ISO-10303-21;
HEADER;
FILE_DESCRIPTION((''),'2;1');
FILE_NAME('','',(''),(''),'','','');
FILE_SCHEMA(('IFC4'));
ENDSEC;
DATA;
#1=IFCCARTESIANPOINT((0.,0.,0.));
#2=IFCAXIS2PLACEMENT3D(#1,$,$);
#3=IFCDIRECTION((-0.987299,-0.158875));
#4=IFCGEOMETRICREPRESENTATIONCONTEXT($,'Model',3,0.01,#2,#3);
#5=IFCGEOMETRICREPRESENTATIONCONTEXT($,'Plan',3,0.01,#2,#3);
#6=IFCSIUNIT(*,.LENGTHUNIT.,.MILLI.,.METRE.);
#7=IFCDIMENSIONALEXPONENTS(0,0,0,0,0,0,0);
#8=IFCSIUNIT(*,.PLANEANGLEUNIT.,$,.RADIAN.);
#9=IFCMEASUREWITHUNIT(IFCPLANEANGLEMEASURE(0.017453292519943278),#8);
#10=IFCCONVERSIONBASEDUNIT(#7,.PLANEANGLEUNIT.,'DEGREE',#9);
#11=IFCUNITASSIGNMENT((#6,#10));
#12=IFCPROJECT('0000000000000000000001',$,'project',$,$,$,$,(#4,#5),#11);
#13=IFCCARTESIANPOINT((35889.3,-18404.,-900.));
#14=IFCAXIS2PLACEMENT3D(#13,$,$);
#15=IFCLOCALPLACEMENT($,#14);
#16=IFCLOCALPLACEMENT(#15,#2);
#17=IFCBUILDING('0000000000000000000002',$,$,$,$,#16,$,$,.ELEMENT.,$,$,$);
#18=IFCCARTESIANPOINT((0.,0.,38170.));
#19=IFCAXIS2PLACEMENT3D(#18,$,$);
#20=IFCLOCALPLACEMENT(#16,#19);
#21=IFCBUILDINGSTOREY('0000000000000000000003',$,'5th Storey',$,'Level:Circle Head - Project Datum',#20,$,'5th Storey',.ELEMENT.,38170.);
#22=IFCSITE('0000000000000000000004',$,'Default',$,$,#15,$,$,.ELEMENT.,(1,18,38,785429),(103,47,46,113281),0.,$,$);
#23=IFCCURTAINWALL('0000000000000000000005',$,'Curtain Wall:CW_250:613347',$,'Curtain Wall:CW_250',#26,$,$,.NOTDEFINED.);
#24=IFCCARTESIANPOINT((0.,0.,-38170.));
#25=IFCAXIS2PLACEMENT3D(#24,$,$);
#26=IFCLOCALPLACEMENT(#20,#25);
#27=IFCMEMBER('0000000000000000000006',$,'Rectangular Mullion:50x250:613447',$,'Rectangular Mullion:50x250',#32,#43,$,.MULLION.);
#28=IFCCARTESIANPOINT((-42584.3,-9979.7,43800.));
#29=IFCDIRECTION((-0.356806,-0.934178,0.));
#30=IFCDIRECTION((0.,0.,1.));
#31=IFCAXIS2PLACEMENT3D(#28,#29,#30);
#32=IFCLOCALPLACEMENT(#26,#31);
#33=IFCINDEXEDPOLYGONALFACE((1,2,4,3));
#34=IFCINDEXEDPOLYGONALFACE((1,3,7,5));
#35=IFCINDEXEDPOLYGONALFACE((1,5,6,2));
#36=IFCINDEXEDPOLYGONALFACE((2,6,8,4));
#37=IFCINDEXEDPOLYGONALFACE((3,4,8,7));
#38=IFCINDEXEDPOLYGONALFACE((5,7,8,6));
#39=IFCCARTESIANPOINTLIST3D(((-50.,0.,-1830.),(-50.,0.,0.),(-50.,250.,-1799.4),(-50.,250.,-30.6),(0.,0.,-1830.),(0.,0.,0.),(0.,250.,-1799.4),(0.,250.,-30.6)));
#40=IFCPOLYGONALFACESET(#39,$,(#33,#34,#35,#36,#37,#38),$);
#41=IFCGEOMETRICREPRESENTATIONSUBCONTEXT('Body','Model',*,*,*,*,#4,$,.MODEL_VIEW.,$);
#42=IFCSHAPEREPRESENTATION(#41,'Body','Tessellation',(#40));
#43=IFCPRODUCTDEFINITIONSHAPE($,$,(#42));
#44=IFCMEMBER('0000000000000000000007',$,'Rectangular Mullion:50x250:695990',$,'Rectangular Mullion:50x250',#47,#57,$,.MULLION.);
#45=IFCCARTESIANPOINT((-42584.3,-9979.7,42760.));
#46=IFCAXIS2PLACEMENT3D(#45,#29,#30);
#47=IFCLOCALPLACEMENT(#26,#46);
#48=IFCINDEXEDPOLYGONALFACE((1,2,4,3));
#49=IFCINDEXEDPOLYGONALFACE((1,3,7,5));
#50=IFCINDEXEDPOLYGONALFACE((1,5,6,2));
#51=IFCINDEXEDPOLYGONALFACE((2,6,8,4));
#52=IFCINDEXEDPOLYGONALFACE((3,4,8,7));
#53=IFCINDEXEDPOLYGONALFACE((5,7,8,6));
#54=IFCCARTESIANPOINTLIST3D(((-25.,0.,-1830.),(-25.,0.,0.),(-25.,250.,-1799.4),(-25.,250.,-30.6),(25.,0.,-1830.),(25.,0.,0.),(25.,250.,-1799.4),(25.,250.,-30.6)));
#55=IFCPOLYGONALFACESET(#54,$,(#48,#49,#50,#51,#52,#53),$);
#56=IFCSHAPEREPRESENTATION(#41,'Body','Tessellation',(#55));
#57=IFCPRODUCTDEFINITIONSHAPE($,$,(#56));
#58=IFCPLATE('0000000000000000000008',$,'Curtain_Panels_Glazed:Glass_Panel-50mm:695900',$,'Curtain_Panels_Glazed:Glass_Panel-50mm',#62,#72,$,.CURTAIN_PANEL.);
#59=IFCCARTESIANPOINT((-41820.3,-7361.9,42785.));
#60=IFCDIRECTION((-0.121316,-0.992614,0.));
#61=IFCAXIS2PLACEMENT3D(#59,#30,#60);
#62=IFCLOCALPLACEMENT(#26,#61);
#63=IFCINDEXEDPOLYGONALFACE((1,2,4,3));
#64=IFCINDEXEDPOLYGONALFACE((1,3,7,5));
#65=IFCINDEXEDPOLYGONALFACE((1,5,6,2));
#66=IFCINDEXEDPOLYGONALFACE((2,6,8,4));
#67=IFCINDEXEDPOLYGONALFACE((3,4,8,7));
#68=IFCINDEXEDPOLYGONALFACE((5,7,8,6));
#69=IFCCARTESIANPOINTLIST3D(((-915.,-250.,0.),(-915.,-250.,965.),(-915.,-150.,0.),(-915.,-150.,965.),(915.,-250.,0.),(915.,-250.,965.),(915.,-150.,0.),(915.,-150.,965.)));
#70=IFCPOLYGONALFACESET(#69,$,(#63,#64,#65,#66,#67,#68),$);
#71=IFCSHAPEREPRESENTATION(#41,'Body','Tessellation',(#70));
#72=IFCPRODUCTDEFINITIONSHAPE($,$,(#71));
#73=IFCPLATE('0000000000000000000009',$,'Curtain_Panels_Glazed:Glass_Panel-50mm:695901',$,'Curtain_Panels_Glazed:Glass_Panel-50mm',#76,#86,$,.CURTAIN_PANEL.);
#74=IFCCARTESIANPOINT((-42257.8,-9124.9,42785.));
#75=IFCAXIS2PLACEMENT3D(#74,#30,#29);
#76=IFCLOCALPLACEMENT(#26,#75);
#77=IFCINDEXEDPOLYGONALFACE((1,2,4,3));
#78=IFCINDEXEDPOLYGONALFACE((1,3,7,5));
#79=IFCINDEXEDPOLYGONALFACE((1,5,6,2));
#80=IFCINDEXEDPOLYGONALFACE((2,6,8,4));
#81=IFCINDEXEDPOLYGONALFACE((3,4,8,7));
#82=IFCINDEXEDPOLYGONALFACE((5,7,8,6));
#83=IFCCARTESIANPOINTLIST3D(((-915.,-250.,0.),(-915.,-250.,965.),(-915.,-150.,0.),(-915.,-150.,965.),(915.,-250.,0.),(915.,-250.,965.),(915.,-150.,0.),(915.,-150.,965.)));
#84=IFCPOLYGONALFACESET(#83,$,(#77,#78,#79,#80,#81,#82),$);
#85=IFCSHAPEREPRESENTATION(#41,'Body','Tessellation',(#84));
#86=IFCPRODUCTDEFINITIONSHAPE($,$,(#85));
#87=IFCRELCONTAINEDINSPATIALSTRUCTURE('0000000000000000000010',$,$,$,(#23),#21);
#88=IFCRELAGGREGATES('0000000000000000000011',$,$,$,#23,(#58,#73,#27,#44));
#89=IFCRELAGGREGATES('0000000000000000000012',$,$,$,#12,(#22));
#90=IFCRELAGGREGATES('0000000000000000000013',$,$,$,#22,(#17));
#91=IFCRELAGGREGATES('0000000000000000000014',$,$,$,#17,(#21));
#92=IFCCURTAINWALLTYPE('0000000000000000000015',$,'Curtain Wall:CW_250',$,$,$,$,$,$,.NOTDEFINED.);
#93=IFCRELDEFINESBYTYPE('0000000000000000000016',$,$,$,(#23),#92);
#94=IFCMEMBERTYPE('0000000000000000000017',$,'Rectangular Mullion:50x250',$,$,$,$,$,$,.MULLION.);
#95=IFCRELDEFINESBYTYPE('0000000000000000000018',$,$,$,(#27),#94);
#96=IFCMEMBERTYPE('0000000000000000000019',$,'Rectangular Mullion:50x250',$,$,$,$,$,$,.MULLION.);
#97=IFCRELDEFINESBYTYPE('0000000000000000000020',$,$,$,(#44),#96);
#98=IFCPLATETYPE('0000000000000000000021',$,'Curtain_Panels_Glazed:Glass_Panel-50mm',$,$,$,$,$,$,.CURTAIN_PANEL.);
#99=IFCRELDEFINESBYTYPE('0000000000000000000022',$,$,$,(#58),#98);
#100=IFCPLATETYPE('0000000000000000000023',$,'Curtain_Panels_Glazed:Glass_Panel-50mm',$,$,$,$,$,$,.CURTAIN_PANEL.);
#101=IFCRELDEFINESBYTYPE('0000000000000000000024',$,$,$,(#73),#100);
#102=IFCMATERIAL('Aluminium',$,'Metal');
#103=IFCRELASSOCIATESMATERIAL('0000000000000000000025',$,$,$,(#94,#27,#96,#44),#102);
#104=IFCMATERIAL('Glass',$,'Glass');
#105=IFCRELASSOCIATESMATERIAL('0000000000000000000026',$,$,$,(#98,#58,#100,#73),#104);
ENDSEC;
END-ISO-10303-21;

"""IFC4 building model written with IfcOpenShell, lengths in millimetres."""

from ifc_helpers import new_model, entity, si_unit, converted_unit, direction, frame, origin, place, context, subcontext, project, spatial, indexed_curve, outline, extrude, source, transform, mapped, material, type_object, type_shapes, element, aggregate, save


model = new_model("IFC4")

# Units and contexts
model_context = context("Model", 3, precision=0.01, world=origin(), true_north=direction((-0.987299, -0.158875)))
plan_context = context("Plan", 3, precision=0.01, world=origin(), true_north=direction((-0.987299, -0.158875)))
body_context = subcontext(model_context, "Body", "Model", "MODEL_VIEW")
ifc_project = project(units=[si_unit("LENGTHUNIT", "METRE", prefix="MILLI"), converted_unit("PLANEANGLEUNIT", "DEGREE", entity("IfcPlaneAngleMeasure", 0.017453292519943278), si_unit("PLANEANGLEUNIT", "RADIAN"), dimensions=[0, 0, 0, 0, 0, 0, 0])], contexts=[model_context, plan_context])

# Site, building, storey
site_placement = place(None, frame((35889.3, -18404.0, -900.0)))
site = spatial("IfcSite", under=ifc_project, at=site_placement, Name="Default", CompositionType="ELEMENT", RefLatitude=(1, 18, 38, 785429), RefLongitude=(103, 47, 46, 113281), RefElevation=0.0)
building_placement = place(site_placement, origin())
building = spatial("IfcBuilding", under=site, at=building_placement, CompositionType="ELEMENT")
storey_placement = place(building_placement, frame((0.0, 0.0, 38170.0)))
storey = spatial("IfcBuildingStorey", under=building, at=storey_placement, Name="5th Storey", ObjectType="Level:Circle Head - Project Datum", LongName="5th Storey", CompositionType="ELEMENT", Elevation=38170.0)

# Curtain wall, member
curtain_wall_type = type_object("IfcCurtainWallType", Name="Curtain Wall:CW_250", PredefinedType="NOTDEFINED")
ifc_material_1 = material(Name="Aluminium", Category="Metal")
curtain_wall_1_placement = place(storey_placement, frame((0.0, 0.0, -38170.0)))
curtain_wall_1 = element("IfcCurtainWall", 1, at=curtain_wall_1_placement, inside=storey, type_object=curtain_wall_type, Name="Curtain Wall:CW_250:613347", ObjectType="Curtain Wall:CW_250", PredefinedType="NOTDEFINED")
member_type_1 = type_object("IfcMemberType", Name="Rectangular Mullion:50x250", PredefinedType="MULLION", material=ifc_material_1)
shared_shape_1 = source(origin(), body_context, "Body", "SweptSolid", [
    extrude(outline(indexed_curve([(-915.0, -125.0), (915.0, -125.0), (884.4, 125.0), (-884.4, 125.0), (-915.0, -125.0)], self_intersect=False)), frame((-50.0, 125.0, -915.0), z_axis=(1.0, 0.0, 0.0), x_axis=(0.0, 0.0, -1.0)), (0.0, 0.0, 1.0), 50.0),
])
type_shapes(member_type_1, [shared_shape_1])
member_1_placement = place(curtain_wall_1_placement, frame((-42584.3, -9979.7, 43800.0), z_axis=(-0.356806, -0.934178, 0.0), x_axis=(0.0, 0.0, 1.0)))
member_1 = element("IfcMember", 2, at=member_1_placement, type_object=member_type_1, material=ifc_material_1, Name="Rectangular Mullion:50x250:613447", ObjectType="Rectangular Mullion:50x250", PredefinedType="MULLION", context=body_context, shape_type="MappedRepresentation", body=[
    mapped(shared_shape_1, transform((0.0, 0.0, 0.0), scale=1.0)),
])

# Member
member_type_2 = type_object("IfcMemberType", Name="Rectangular Mullion:50x250", PredefinedType="MULLION", material=ifc_material_1)
shared_shape_2 = source(origin(), body_context, "Body", "SweptSolid", [
    extrude(outline(indexed_curve([(-915.0, -125.0), (915.0, -125.0), (884.4, 125.0), (-884.4, 125.0), (-915.0, -125.0)], self_intersect=False)), frame((-25.0, 125.0, -915.0), z_axis=(1.0, 0.0, 0.0), x_axis=(0.0, 0.0, -1.0)), (0.0, 0.0, 1.0), 50.0),
])
type_shapes(member_type_2, [shared_shape_2])
member_2_placement = place(curtain_wall_1_placement, frame((-42584.3, -9979.7, 42760.0), z_axis=(-0.356806, -0.934178, 0.0), x_axis=(0.0, 0.0, 1.0)))
member_2 = element("IfcMember", 3, at=member_2_placement, type_object=member_type_2, material=ifc_material_1, Name="Rectangular Mullion:50x250:695990", ObjectType="Rectangular Mullion:50x250", PredefinedType="MULLION", context=body_context, shape_type="MappedRepresentation", body=[
    mapped(shared_shape_2, transform((0.0, 0.0, 0.0), scale=1.0)),
])

# Plates
ifc_material_2 = material(Name="Glass", Category="Glass")
plate_type_1 = type_object("IfcPlateType", Name="Curtain_Panels_Glazed:Glass_Panel-50mm", PredefinedType="CURTAIN_PANEL", material=ifc_material_2)
shared_shape_3 = source(origin(), body_context, "Body", "SweptSolid", [
    extrude(outline(indexed_curve([(-915.0, -50.0), (915.0, -50.0), (915.0, 50.0), (-915.0, 50.0), (-915.0, -50.0)], self_intersect=False)), frame((0.0, -200.0, 0.0), z_axis=(0.0, 0.0, 1.0), x_axis=(-1.0, 0.0, 0.0)), (0.0, 0.0, 1.0), 965.0),
])
type_shapes(plate_type_1, [shared_shape_3])
plate_1_placement = place(curtain_wall_1_placement, frame((-41820.3, -7361.9, 42785.0), z_axis=(0.0, 0.0, 1.0), x_axis=(-0.121316, -0.992614, 0.0)))
plate_1 = element("IfcPlate", 4, at=plate_1_placement, type_object=plate_type_1, material=ifc_material_2, Name="Curtain_Panels_Glazed:Glass_Panel-50mm:695900", ObjectType="Curtain_Panels_Glazed:Glass_Panel-50mm", PredefinedType="CURTAIN_PANEL", context=body_context, shape_type="MappedRepresentation", body=[
    mapped(shared_shape_3, transform((0.0, 0.0, 0.0), scale=1.0)),
])
plate_type_2 = type_object("IfcPlateType", Name="Curtain_Panels_Glazed:Glass_Panel-50mm", PredefinedType="CURTAIN_PANEL", material=ifc_material_2)
shared_shape_4 = source(origin(), body_context, "Body", "SweptSolid", [
    extrude(outline(indexed_curve([(-915.0, -50.0), (915.0, -50.0), (915.0, 50.0), (-915.0, 50.0), (-915.0, -50.0)], self_intersect=False)), frame((0.0, -200.0, 0.0), z_axis=(0.0, 0.0, 1.0), x_axis=(-1.0, 0.0, 0.0)), (0.0, 0.0, 1.0), 965.0),
])
type_shapes(plate_type_2, [shared_shape_4])
plate_2_placement = place(curtain_wall_1_placement, frame((-42257.8, -9124.9, 42785.0), z_axis=(0.0, 0.0, 1.0), x_axis=(-0.356806, -0.934178, 0.0)))
plate_2 = element("IfcPlate", 5, at=plate_2_placement, type_object=plate_type_2, material=ifc_material_2, Name="Curtain_Panels_Glazed:Glass_Panel-50mm:695901", ObjectType="Curtain_Panels_Glazed:Glass_Panel-50mm", PredefinedType="CURTAIN_PANEL", context=body_context, shape_type="MappedRepresentation", body=[
    mapped(shared_shape_4, transform((0.0, 0.0, 0.0), scale=1.0)),
])
aggregate(curtain_wall_1, [plate_1, plate_2, member_1, member_2])

save(model, "model.ifc")
